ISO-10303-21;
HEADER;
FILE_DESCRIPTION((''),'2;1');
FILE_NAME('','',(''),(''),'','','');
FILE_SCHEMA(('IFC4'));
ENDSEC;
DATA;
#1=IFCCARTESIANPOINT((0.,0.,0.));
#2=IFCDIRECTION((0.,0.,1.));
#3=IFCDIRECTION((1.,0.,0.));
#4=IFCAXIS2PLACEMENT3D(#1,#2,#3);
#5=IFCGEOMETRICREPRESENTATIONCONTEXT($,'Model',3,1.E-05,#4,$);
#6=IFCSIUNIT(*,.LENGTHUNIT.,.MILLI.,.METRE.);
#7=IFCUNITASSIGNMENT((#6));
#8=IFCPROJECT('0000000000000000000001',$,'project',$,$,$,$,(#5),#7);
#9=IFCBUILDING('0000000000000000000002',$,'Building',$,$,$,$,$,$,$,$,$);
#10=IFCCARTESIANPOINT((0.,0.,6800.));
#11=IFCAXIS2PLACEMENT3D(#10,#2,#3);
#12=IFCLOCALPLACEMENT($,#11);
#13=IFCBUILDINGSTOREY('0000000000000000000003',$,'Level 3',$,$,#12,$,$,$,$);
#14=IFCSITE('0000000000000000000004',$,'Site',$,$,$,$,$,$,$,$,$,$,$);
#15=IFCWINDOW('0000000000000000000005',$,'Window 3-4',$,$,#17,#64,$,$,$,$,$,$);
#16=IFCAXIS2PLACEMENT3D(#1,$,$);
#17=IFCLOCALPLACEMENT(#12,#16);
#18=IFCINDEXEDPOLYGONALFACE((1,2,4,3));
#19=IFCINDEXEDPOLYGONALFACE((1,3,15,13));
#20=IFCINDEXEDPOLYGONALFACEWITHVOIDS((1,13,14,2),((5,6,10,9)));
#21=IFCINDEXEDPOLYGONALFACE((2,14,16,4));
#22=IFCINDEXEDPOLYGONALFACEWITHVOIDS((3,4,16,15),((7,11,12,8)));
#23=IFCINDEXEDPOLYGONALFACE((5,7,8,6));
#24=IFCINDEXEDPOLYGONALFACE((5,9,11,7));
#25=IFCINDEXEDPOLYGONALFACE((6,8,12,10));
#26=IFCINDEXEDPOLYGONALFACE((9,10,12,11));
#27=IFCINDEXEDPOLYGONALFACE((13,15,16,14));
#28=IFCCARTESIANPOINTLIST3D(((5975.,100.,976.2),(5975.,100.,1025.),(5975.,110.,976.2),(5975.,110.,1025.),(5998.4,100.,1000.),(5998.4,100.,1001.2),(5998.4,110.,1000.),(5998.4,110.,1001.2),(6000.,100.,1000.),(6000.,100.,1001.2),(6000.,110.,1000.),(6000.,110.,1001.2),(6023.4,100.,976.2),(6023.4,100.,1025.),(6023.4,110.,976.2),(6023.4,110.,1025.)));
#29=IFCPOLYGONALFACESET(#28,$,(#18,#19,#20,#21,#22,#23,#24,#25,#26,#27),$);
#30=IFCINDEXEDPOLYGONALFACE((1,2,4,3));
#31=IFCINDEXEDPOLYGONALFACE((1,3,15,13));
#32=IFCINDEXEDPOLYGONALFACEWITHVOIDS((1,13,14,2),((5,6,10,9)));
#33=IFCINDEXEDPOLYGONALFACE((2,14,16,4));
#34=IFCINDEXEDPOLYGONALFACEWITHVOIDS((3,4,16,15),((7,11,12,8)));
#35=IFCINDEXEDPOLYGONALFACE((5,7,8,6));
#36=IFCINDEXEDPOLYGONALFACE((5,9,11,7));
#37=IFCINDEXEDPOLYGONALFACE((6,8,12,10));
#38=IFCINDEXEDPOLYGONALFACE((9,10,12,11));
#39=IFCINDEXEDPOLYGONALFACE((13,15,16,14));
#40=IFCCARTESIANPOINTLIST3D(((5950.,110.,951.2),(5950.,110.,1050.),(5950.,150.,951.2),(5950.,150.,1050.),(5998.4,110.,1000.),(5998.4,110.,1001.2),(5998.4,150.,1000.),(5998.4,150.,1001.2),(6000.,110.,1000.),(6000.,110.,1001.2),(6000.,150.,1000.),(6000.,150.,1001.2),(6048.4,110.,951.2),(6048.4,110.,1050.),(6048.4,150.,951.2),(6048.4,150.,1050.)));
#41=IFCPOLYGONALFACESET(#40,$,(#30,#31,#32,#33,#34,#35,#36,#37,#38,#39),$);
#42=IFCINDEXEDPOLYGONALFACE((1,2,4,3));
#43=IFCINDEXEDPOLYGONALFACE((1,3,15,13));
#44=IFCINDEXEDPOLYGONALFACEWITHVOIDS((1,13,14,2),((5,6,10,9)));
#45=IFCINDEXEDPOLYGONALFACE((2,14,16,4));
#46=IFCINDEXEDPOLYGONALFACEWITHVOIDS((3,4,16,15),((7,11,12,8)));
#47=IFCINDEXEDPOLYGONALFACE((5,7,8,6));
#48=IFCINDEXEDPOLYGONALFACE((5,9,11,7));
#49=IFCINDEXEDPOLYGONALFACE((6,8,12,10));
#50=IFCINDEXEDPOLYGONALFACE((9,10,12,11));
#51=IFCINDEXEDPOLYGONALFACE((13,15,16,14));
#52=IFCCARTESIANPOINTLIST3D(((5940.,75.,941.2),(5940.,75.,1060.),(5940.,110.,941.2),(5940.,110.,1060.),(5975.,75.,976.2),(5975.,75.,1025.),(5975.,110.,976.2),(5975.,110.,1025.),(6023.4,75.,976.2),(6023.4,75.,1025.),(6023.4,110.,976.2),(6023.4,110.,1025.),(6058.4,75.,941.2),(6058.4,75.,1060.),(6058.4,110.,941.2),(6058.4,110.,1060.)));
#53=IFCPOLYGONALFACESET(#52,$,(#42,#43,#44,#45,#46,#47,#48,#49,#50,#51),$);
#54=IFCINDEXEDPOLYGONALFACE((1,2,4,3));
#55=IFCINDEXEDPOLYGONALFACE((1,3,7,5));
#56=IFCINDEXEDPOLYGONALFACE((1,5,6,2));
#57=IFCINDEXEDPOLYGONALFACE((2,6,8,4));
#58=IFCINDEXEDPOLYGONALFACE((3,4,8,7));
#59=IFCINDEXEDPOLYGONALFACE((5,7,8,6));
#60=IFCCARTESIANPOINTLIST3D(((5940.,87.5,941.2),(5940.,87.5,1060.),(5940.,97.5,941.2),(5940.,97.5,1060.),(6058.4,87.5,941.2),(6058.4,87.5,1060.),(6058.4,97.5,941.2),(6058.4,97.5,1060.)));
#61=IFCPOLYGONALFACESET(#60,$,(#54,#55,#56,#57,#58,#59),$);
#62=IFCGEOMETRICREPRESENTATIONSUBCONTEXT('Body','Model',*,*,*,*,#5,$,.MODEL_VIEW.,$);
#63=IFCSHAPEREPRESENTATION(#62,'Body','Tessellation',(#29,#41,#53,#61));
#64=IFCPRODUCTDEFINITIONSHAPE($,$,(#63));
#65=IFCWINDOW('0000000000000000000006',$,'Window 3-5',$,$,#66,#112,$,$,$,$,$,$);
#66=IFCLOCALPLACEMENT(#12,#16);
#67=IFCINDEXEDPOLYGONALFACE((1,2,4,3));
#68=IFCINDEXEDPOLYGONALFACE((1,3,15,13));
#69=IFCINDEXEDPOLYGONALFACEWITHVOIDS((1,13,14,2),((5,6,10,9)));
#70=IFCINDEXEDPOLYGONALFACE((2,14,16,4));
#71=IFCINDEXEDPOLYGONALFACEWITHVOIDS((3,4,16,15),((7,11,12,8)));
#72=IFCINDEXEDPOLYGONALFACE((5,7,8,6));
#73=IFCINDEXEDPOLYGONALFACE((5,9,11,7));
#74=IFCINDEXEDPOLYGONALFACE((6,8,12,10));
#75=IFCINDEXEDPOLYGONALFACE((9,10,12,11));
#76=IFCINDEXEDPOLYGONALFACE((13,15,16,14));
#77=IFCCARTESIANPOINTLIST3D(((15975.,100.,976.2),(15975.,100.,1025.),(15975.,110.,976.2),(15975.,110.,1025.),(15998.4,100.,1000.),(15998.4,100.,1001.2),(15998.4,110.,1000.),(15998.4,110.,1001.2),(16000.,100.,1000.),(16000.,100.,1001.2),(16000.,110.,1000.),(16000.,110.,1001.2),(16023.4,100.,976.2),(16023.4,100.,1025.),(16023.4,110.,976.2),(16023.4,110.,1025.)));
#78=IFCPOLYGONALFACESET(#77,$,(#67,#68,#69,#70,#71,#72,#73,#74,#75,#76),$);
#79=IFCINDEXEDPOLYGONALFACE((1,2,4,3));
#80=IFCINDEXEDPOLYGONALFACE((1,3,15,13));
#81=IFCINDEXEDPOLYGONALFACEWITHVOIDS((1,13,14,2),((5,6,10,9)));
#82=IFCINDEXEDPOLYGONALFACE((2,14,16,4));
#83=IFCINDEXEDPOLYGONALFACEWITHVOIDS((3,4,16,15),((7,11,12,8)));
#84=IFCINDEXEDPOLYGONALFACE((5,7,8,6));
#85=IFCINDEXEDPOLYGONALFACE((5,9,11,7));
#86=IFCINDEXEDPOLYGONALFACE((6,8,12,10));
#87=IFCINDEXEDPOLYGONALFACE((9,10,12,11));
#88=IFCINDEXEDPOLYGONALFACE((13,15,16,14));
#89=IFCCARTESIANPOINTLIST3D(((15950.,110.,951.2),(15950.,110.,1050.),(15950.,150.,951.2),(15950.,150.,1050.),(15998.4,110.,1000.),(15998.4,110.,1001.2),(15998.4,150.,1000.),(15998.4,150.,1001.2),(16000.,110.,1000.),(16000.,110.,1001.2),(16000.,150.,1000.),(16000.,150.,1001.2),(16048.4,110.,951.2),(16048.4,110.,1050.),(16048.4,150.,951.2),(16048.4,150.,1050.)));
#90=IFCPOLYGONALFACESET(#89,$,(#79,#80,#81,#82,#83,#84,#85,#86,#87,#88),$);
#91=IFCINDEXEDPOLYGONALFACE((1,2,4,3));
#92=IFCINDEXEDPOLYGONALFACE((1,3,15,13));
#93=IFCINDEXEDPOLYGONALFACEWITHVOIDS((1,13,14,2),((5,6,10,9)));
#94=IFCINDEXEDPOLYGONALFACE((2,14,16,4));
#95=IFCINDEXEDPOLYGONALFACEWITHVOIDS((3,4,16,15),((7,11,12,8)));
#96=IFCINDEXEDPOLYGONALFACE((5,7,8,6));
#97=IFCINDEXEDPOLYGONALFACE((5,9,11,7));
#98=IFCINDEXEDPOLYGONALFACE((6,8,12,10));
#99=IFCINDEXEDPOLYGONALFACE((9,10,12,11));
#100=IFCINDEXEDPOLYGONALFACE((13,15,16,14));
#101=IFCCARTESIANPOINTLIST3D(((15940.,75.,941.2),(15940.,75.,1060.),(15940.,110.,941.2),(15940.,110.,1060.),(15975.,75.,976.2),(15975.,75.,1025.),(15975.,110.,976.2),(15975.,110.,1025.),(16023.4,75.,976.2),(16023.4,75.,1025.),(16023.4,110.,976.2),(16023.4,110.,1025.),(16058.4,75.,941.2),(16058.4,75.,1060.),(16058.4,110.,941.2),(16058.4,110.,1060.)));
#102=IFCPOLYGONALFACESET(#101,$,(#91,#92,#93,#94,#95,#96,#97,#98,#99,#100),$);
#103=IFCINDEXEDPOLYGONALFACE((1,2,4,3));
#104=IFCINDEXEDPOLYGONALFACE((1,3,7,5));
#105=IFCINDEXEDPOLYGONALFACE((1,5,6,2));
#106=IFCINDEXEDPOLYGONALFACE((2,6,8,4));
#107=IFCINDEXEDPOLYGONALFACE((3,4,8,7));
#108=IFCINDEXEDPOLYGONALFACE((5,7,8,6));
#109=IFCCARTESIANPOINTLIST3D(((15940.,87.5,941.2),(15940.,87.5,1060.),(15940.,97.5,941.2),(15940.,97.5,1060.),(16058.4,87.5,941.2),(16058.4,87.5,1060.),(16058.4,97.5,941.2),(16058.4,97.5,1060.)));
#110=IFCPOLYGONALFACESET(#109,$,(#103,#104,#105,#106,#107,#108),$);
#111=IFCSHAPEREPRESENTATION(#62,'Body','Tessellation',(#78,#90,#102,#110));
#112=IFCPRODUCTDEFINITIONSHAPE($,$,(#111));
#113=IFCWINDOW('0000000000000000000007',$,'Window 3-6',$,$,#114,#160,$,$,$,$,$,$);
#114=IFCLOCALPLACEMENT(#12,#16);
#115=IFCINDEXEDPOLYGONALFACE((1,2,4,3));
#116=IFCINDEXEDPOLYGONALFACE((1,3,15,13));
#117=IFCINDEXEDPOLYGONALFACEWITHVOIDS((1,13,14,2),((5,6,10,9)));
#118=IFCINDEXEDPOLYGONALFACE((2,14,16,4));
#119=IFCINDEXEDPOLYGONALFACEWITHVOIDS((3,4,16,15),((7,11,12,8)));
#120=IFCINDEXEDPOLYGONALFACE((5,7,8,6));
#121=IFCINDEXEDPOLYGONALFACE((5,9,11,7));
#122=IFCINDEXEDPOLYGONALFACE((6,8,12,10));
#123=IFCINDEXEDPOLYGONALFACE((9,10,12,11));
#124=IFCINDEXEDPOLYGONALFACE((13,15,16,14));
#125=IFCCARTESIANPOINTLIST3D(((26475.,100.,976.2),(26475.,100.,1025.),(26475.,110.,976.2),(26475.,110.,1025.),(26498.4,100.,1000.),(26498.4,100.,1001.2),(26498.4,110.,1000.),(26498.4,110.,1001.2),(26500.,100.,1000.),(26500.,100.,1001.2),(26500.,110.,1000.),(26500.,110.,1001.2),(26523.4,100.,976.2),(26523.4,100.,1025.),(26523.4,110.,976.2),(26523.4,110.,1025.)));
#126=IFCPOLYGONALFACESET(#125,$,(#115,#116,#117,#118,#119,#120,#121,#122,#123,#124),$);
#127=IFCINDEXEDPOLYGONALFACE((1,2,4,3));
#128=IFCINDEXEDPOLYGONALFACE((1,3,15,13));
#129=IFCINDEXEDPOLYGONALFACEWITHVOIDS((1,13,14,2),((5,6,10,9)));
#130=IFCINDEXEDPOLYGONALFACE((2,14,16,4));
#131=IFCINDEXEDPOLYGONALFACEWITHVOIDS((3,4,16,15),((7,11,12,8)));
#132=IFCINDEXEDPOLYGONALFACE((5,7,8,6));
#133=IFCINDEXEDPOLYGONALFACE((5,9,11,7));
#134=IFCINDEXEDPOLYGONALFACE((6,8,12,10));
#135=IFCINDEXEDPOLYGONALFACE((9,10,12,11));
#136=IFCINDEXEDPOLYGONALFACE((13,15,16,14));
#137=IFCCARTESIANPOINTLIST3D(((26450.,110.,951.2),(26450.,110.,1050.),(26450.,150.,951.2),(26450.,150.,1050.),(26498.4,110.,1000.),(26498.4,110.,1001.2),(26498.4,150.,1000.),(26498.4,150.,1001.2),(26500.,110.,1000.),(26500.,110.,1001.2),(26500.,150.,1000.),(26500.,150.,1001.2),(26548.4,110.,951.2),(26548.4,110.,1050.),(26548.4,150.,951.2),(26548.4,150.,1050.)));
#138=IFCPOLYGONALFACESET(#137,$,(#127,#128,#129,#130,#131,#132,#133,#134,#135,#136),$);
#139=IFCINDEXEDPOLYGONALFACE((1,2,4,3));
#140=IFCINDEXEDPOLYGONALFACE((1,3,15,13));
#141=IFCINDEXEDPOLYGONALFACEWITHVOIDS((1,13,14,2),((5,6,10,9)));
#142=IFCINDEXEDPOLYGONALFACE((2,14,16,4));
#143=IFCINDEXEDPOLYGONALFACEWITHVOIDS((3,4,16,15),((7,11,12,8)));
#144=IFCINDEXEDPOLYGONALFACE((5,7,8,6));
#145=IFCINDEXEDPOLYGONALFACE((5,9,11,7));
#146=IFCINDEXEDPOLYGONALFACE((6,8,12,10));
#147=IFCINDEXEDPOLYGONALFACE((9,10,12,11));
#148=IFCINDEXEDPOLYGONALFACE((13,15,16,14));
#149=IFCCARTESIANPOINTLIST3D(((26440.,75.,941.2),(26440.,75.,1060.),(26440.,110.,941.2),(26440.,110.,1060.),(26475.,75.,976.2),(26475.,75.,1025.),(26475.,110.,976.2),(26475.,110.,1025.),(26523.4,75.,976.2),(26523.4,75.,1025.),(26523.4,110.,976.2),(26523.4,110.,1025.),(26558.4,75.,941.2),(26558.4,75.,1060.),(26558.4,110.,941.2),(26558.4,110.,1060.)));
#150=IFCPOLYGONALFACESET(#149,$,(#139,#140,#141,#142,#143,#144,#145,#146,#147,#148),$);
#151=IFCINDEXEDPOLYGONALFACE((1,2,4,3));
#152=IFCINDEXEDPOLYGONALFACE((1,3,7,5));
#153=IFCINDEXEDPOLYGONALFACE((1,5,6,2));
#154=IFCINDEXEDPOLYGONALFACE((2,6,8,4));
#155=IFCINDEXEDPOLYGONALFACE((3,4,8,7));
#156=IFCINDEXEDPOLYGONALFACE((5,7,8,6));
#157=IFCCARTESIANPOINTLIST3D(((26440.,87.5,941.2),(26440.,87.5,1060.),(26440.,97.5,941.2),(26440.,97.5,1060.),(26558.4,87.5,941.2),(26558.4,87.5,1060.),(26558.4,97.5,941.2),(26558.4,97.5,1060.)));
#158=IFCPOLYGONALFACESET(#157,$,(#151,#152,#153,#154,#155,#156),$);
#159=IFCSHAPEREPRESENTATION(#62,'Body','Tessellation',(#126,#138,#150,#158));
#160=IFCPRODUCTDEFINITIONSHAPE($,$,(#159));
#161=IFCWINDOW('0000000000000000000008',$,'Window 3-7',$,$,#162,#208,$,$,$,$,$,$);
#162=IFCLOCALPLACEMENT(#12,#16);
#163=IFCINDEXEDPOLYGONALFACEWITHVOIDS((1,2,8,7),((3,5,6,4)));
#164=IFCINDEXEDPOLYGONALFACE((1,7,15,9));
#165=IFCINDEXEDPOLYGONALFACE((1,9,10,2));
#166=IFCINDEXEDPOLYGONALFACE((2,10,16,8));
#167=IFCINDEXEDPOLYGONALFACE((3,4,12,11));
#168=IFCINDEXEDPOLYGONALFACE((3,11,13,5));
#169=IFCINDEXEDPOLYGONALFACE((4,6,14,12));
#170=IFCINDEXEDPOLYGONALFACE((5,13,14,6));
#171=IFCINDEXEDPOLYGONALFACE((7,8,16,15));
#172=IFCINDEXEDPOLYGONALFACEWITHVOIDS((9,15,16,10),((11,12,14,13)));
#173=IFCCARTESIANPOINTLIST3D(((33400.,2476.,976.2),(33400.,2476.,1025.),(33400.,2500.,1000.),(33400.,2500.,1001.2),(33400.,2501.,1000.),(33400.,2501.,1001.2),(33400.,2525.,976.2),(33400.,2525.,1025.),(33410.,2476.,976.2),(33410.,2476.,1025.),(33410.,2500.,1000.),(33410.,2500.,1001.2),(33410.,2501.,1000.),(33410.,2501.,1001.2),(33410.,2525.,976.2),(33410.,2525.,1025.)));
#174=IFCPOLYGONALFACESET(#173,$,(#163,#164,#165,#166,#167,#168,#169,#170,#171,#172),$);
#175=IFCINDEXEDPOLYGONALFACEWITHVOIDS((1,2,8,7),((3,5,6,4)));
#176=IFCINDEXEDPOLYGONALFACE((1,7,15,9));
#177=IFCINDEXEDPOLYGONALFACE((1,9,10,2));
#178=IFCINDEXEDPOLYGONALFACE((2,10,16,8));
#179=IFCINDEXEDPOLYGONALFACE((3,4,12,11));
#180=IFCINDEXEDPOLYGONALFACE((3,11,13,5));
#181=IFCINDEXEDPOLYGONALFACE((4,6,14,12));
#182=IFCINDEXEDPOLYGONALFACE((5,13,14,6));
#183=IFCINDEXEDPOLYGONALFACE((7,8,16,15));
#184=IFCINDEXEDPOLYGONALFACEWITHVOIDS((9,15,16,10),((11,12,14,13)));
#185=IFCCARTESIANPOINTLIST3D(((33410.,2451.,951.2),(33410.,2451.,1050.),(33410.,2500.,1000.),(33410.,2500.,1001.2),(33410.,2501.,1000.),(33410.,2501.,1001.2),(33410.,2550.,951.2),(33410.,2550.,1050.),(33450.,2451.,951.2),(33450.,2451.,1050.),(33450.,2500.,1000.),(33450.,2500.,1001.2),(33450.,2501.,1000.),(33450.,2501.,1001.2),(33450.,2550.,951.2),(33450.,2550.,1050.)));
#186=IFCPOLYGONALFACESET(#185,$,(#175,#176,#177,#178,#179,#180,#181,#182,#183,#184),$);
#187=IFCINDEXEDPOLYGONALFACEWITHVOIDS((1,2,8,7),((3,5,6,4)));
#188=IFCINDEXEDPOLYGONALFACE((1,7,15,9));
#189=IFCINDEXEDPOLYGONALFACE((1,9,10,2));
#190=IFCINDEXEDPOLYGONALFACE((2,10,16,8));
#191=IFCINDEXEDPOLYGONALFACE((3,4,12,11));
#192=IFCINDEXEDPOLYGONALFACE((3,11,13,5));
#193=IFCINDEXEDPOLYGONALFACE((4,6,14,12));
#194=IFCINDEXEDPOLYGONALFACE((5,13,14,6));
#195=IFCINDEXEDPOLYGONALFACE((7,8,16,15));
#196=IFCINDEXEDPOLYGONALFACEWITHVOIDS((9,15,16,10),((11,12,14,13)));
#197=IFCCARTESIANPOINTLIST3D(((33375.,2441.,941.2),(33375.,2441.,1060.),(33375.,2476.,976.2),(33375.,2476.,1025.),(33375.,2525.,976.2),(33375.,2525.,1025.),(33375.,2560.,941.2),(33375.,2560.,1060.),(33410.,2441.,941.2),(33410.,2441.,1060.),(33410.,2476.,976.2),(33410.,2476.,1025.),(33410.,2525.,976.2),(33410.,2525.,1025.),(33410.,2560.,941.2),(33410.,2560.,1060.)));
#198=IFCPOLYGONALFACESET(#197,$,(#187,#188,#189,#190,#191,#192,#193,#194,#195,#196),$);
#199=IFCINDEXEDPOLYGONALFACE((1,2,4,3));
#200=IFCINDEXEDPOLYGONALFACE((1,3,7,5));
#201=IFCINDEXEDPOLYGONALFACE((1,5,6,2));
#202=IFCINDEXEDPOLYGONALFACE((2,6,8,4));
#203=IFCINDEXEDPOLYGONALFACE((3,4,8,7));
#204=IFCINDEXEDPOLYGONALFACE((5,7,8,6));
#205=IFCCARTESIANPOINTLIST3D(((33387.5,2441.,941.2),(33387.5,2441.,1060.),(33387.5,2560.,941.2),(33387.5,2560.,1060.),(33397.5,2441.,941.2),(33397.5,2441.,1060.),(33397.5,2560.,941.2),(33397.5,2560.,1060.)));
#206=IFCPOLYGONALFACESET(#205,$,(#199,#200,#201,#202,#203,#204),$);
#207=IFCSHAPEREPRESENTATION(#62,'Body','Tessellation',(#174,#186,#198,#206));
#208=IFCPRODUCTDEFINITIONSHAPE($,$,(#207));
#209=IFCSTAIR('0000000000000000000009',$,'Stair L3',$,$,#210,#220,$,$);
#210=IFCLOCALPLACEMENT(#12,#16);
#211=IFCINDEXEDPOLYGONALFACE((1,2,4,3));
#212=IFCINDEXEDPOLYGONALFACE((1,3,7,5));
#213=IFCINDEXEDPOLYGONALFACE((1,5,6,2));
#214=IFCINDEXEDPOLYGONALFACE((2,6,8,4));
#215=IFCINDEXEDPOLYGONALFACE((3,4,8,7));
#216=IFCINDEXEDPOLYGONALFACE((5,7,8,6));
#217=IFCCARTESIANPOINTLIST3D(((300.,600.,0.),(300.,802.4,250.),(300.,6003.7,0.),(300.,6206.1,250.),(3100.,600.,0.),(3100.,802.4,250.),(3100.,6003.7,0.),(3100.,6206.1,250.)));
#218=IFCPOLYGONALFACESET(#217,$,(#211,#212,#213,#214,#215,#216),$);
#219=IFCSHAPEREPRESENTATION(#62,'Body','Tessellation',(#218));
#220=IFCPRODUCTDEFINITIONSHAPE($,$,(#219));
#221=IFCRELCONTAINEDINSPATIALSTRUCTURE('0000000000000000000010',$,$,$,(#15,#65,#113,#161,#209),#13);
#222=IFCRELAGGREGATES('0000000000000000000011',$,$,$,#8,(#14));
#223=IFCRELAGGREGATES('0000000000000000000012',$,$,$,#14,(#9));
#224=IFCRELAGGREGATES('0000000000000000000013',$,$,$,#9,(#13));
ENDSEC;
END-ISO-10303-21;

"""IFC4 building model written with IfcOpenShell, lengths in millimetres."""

from ifc_helpers import new_model, si_unit, frame, origin_with_axes, place, context, subcontext, project, spatial, line, indexed_curve, outline, extrude, element, save


model = new_model("IFC4")

# Units and contexts
model_context = context("Model", 3, precision=1e-05, world=origin_with_axes())
body_context = subcontext(model_context, "Body", "Model", "MODEL_VIEW")
ifc_project = project(units=[si_unit("LENGTHUNIT", "METRE", prefix="MILLI")], contexts=[model_context])

# Site, building, storey
site = spatial("IfcSite", under=ifc_project, Name="Site")
building = spatial("IfcBuilding", under=site, Name="Building")
storey_placement = place(None, frame((0.0, 0.0, 6800.0), z_axis=(0.0, 0.0, 1.0), x_axis=(1.0, 0.0, 0.0)))
storey = spatial("IfcBuildingStorey", under=building, at=storey_placement, Name="Level 3")

# Windows
for number, where, z_axis, x_axis, name in (
    (1, (6000.0, 200.0, 1000.0), (0.0, 0.0, 1.0), (-1.0, 0.0, 0.0), "Window 3-4"),
    (2, (16000.0, 200.0, 1000.0), (0.0, 0.0, 1.0), (-1.0, 0.0, 0.0), "Window 3-5"),
    (3, (26500.0, 200.0, 1000.0), (0.0, 0.0, 1.0), (-1.0, 0.0, 0.0), "Window 3-6"),
):
    element("IfcWindow", number, at=place(storey_placement, frame(where, z_axis=z_axis, x_axis=x_axis)), inside=storey, Name=name, context=body_context, shape_type="SweptSolid", body=[
        extrude(outline(indexed_curve([(0.0, 0.0), (1.6, 0.0), (1.6, 1.2), (0.0, 1.2)], segments=[line(1, 2, 3, 4, 1)]), holes=[indexed_curve([(25.0, 25.0), (-23.4, 25.0), (-23.4, -23.8), (25.0, -23.8)], segments=[line(1, 2, 3, 4, 1)])]), frame((0.0, 90.0, 0.0), z_axis=(0.0, -1.0, 0.0), x_axis=(1.0, 0.0, 0.0)), (0.0, 0.0, -1.0), 10.0),
        extrude(outline(indexed_curve([(0.0, 0.0), (1.6, 0.0), (1.6, 1.2), (0.0, 1.2)], segments=[line(1, 2, 3, 4, 1)]), holes=[indexed_curve([(50.0, 50.0), (-48.4, 50.0), (-48.4, -48.8), (50.0, -48.8)], segments=[line(1, 2, 3, 4, 1)])]), frame((0.0, 50.0, 0.0), z_axis=(0.0, -1.0, 0.0), x_axis=(1.0, 0.0, 0.0)), (0.0, 0.0, -1.0), 40.0),
        extrude(outline(indexed_curve([(0.0, 0.0), (-48.4, 0.0), (-48.4, -48.8), (0.0, -48.8)], segments=[line(1, 2, 3, 4, 1)]), holes=[indexed_curve([(35.0, 35.0), (-83.4, 35.0), (-83.4, -83.8), (35.0, -83.8)], segments=[line(1, 2, 3, 4, 1)])]), frame((25.0, 90.0, 25.0), z_axis=(0.0, -1.0, 0.0), x_axis=(1.0, 0.0, 0.0)), (0.0, 0.0, -1.0), 35.0),
        extrude(outline(indexed_curve([(35.0, 35.0), (-83.4, 35.0), (-83.4, -83.8), (35.0, -83.8)], segments=[line(1, 2, 3, 4, 1)])), frame((25.0, 102.5, 25.0), z_axis=(0.0, -1.0, 0.0), x_axis=(1.0, 0.0, 0.0)), (0.0, 0.0, -1.0), 10.0),
    ])
window_placement = place(storey_placement, frame((33500.0, 2500.0, 1000.0), z_axis=(0.0, 0.0, 1.0), x_axis=(0.0, 1.0, 0.0)))
element("IfcWindow", 4, at=window_placement, inside=storey, Name="Window 3-7", context=body_context, shape_type="SweptSolid", body=[
    extrude(outline(indexed_curve([(0.0, 0.0), (1.0, 0.0), (1.0, 1.2), (0.0, 1.2)], segments=[line(1, 2, 3, 4, 1)]), holes=[indexed_curve([(25.0, 25.0), (-24.0, 25.0), (-24.0, -23.8), (25.0, -23.8)], segments=[line(1, 2, 3, 4, 1)])]), frame((0.0, 90.0, 0.0), z_axis=(0.0, -1.0, 0.0), x_axis=(1.0, 0.0, 0.0)), (0.0, 0.0, -1.0), 10.0),
    extrude(outline(indexed_curve([(0.0, 0.0), (1.0, 0.0), (1.0, 1.2), (0.0, 1.2)], segments=[line(1, 2, 3, 4, 1)]), holes=[indexed_curve([(50.0, 50.0), (-49.0, 50.0), (-49.0, -48.8), (50.0, -48.8)], segments=[line(1, 2, 3, 4, 1)])]), frame((0.0, 50.0, 0.0), z_axis=(0.0, -1.0, 0.0), x_axis=(1.0, 0.0, 0.0)), (0.0, 0.0, -1.0), 40.0),
    extrude(outline(indexed_curve([(0.0, 0.0), (-49.0, 0.0), (-49.0, -48.8), (0.0, -48.8)], segments=[line(1, 2, 3, 4, 1)]), holes=[indexed_curve([(35.0, 35.0), (-84.0, 35.0), (-84.0, -83.8), (35.0, -83.8)], segments=[line(1, 2, 3, 4, 1)])]), frame((25.0, 90.0, 25.0), z_axis=(0.0, -1.0, 0.0), x_axis=(1.0, 0.0, 0.0)), (0.0, 0.0, -1.0), 35.0),
    extrude(outline(indexed_curve([(35.0, 35.0), (-84.0, 35.0), (-84.0, -83.8), (35.0, -83.8)], segments=[line(1, 2, 3, 4, 1)])), frame((25.0, 102.5, 25.0), z_axis=(0.0, -1.0, 0.0), x_axis=(1.0, 0.0, 0.0)), (0.0, 0.0, -1.0), 10.0),
])

# Stair
stair_placement = place(storey_placement, frame((300.0, 600.0, 0.0), z_axis=(0.0, 0.0, 1.0), x_axis=(1.0, 0.0, 0.0)))
element("IfcStair", 5, at=stair_placement, inside=storey, Name="Stair L3", context=body_context, shape_type="SweptSolid", body=[
    extrude(outline(indexed_curve([(0.0, 0.0), (2800.0, 0.0), (2800.0, 5403.7), (0.0, 5403.7), (0.0, 0.0)])), None, (0.0, 0.629198, 0.777245), 321.6),
])

save(model, "model.ifc")
